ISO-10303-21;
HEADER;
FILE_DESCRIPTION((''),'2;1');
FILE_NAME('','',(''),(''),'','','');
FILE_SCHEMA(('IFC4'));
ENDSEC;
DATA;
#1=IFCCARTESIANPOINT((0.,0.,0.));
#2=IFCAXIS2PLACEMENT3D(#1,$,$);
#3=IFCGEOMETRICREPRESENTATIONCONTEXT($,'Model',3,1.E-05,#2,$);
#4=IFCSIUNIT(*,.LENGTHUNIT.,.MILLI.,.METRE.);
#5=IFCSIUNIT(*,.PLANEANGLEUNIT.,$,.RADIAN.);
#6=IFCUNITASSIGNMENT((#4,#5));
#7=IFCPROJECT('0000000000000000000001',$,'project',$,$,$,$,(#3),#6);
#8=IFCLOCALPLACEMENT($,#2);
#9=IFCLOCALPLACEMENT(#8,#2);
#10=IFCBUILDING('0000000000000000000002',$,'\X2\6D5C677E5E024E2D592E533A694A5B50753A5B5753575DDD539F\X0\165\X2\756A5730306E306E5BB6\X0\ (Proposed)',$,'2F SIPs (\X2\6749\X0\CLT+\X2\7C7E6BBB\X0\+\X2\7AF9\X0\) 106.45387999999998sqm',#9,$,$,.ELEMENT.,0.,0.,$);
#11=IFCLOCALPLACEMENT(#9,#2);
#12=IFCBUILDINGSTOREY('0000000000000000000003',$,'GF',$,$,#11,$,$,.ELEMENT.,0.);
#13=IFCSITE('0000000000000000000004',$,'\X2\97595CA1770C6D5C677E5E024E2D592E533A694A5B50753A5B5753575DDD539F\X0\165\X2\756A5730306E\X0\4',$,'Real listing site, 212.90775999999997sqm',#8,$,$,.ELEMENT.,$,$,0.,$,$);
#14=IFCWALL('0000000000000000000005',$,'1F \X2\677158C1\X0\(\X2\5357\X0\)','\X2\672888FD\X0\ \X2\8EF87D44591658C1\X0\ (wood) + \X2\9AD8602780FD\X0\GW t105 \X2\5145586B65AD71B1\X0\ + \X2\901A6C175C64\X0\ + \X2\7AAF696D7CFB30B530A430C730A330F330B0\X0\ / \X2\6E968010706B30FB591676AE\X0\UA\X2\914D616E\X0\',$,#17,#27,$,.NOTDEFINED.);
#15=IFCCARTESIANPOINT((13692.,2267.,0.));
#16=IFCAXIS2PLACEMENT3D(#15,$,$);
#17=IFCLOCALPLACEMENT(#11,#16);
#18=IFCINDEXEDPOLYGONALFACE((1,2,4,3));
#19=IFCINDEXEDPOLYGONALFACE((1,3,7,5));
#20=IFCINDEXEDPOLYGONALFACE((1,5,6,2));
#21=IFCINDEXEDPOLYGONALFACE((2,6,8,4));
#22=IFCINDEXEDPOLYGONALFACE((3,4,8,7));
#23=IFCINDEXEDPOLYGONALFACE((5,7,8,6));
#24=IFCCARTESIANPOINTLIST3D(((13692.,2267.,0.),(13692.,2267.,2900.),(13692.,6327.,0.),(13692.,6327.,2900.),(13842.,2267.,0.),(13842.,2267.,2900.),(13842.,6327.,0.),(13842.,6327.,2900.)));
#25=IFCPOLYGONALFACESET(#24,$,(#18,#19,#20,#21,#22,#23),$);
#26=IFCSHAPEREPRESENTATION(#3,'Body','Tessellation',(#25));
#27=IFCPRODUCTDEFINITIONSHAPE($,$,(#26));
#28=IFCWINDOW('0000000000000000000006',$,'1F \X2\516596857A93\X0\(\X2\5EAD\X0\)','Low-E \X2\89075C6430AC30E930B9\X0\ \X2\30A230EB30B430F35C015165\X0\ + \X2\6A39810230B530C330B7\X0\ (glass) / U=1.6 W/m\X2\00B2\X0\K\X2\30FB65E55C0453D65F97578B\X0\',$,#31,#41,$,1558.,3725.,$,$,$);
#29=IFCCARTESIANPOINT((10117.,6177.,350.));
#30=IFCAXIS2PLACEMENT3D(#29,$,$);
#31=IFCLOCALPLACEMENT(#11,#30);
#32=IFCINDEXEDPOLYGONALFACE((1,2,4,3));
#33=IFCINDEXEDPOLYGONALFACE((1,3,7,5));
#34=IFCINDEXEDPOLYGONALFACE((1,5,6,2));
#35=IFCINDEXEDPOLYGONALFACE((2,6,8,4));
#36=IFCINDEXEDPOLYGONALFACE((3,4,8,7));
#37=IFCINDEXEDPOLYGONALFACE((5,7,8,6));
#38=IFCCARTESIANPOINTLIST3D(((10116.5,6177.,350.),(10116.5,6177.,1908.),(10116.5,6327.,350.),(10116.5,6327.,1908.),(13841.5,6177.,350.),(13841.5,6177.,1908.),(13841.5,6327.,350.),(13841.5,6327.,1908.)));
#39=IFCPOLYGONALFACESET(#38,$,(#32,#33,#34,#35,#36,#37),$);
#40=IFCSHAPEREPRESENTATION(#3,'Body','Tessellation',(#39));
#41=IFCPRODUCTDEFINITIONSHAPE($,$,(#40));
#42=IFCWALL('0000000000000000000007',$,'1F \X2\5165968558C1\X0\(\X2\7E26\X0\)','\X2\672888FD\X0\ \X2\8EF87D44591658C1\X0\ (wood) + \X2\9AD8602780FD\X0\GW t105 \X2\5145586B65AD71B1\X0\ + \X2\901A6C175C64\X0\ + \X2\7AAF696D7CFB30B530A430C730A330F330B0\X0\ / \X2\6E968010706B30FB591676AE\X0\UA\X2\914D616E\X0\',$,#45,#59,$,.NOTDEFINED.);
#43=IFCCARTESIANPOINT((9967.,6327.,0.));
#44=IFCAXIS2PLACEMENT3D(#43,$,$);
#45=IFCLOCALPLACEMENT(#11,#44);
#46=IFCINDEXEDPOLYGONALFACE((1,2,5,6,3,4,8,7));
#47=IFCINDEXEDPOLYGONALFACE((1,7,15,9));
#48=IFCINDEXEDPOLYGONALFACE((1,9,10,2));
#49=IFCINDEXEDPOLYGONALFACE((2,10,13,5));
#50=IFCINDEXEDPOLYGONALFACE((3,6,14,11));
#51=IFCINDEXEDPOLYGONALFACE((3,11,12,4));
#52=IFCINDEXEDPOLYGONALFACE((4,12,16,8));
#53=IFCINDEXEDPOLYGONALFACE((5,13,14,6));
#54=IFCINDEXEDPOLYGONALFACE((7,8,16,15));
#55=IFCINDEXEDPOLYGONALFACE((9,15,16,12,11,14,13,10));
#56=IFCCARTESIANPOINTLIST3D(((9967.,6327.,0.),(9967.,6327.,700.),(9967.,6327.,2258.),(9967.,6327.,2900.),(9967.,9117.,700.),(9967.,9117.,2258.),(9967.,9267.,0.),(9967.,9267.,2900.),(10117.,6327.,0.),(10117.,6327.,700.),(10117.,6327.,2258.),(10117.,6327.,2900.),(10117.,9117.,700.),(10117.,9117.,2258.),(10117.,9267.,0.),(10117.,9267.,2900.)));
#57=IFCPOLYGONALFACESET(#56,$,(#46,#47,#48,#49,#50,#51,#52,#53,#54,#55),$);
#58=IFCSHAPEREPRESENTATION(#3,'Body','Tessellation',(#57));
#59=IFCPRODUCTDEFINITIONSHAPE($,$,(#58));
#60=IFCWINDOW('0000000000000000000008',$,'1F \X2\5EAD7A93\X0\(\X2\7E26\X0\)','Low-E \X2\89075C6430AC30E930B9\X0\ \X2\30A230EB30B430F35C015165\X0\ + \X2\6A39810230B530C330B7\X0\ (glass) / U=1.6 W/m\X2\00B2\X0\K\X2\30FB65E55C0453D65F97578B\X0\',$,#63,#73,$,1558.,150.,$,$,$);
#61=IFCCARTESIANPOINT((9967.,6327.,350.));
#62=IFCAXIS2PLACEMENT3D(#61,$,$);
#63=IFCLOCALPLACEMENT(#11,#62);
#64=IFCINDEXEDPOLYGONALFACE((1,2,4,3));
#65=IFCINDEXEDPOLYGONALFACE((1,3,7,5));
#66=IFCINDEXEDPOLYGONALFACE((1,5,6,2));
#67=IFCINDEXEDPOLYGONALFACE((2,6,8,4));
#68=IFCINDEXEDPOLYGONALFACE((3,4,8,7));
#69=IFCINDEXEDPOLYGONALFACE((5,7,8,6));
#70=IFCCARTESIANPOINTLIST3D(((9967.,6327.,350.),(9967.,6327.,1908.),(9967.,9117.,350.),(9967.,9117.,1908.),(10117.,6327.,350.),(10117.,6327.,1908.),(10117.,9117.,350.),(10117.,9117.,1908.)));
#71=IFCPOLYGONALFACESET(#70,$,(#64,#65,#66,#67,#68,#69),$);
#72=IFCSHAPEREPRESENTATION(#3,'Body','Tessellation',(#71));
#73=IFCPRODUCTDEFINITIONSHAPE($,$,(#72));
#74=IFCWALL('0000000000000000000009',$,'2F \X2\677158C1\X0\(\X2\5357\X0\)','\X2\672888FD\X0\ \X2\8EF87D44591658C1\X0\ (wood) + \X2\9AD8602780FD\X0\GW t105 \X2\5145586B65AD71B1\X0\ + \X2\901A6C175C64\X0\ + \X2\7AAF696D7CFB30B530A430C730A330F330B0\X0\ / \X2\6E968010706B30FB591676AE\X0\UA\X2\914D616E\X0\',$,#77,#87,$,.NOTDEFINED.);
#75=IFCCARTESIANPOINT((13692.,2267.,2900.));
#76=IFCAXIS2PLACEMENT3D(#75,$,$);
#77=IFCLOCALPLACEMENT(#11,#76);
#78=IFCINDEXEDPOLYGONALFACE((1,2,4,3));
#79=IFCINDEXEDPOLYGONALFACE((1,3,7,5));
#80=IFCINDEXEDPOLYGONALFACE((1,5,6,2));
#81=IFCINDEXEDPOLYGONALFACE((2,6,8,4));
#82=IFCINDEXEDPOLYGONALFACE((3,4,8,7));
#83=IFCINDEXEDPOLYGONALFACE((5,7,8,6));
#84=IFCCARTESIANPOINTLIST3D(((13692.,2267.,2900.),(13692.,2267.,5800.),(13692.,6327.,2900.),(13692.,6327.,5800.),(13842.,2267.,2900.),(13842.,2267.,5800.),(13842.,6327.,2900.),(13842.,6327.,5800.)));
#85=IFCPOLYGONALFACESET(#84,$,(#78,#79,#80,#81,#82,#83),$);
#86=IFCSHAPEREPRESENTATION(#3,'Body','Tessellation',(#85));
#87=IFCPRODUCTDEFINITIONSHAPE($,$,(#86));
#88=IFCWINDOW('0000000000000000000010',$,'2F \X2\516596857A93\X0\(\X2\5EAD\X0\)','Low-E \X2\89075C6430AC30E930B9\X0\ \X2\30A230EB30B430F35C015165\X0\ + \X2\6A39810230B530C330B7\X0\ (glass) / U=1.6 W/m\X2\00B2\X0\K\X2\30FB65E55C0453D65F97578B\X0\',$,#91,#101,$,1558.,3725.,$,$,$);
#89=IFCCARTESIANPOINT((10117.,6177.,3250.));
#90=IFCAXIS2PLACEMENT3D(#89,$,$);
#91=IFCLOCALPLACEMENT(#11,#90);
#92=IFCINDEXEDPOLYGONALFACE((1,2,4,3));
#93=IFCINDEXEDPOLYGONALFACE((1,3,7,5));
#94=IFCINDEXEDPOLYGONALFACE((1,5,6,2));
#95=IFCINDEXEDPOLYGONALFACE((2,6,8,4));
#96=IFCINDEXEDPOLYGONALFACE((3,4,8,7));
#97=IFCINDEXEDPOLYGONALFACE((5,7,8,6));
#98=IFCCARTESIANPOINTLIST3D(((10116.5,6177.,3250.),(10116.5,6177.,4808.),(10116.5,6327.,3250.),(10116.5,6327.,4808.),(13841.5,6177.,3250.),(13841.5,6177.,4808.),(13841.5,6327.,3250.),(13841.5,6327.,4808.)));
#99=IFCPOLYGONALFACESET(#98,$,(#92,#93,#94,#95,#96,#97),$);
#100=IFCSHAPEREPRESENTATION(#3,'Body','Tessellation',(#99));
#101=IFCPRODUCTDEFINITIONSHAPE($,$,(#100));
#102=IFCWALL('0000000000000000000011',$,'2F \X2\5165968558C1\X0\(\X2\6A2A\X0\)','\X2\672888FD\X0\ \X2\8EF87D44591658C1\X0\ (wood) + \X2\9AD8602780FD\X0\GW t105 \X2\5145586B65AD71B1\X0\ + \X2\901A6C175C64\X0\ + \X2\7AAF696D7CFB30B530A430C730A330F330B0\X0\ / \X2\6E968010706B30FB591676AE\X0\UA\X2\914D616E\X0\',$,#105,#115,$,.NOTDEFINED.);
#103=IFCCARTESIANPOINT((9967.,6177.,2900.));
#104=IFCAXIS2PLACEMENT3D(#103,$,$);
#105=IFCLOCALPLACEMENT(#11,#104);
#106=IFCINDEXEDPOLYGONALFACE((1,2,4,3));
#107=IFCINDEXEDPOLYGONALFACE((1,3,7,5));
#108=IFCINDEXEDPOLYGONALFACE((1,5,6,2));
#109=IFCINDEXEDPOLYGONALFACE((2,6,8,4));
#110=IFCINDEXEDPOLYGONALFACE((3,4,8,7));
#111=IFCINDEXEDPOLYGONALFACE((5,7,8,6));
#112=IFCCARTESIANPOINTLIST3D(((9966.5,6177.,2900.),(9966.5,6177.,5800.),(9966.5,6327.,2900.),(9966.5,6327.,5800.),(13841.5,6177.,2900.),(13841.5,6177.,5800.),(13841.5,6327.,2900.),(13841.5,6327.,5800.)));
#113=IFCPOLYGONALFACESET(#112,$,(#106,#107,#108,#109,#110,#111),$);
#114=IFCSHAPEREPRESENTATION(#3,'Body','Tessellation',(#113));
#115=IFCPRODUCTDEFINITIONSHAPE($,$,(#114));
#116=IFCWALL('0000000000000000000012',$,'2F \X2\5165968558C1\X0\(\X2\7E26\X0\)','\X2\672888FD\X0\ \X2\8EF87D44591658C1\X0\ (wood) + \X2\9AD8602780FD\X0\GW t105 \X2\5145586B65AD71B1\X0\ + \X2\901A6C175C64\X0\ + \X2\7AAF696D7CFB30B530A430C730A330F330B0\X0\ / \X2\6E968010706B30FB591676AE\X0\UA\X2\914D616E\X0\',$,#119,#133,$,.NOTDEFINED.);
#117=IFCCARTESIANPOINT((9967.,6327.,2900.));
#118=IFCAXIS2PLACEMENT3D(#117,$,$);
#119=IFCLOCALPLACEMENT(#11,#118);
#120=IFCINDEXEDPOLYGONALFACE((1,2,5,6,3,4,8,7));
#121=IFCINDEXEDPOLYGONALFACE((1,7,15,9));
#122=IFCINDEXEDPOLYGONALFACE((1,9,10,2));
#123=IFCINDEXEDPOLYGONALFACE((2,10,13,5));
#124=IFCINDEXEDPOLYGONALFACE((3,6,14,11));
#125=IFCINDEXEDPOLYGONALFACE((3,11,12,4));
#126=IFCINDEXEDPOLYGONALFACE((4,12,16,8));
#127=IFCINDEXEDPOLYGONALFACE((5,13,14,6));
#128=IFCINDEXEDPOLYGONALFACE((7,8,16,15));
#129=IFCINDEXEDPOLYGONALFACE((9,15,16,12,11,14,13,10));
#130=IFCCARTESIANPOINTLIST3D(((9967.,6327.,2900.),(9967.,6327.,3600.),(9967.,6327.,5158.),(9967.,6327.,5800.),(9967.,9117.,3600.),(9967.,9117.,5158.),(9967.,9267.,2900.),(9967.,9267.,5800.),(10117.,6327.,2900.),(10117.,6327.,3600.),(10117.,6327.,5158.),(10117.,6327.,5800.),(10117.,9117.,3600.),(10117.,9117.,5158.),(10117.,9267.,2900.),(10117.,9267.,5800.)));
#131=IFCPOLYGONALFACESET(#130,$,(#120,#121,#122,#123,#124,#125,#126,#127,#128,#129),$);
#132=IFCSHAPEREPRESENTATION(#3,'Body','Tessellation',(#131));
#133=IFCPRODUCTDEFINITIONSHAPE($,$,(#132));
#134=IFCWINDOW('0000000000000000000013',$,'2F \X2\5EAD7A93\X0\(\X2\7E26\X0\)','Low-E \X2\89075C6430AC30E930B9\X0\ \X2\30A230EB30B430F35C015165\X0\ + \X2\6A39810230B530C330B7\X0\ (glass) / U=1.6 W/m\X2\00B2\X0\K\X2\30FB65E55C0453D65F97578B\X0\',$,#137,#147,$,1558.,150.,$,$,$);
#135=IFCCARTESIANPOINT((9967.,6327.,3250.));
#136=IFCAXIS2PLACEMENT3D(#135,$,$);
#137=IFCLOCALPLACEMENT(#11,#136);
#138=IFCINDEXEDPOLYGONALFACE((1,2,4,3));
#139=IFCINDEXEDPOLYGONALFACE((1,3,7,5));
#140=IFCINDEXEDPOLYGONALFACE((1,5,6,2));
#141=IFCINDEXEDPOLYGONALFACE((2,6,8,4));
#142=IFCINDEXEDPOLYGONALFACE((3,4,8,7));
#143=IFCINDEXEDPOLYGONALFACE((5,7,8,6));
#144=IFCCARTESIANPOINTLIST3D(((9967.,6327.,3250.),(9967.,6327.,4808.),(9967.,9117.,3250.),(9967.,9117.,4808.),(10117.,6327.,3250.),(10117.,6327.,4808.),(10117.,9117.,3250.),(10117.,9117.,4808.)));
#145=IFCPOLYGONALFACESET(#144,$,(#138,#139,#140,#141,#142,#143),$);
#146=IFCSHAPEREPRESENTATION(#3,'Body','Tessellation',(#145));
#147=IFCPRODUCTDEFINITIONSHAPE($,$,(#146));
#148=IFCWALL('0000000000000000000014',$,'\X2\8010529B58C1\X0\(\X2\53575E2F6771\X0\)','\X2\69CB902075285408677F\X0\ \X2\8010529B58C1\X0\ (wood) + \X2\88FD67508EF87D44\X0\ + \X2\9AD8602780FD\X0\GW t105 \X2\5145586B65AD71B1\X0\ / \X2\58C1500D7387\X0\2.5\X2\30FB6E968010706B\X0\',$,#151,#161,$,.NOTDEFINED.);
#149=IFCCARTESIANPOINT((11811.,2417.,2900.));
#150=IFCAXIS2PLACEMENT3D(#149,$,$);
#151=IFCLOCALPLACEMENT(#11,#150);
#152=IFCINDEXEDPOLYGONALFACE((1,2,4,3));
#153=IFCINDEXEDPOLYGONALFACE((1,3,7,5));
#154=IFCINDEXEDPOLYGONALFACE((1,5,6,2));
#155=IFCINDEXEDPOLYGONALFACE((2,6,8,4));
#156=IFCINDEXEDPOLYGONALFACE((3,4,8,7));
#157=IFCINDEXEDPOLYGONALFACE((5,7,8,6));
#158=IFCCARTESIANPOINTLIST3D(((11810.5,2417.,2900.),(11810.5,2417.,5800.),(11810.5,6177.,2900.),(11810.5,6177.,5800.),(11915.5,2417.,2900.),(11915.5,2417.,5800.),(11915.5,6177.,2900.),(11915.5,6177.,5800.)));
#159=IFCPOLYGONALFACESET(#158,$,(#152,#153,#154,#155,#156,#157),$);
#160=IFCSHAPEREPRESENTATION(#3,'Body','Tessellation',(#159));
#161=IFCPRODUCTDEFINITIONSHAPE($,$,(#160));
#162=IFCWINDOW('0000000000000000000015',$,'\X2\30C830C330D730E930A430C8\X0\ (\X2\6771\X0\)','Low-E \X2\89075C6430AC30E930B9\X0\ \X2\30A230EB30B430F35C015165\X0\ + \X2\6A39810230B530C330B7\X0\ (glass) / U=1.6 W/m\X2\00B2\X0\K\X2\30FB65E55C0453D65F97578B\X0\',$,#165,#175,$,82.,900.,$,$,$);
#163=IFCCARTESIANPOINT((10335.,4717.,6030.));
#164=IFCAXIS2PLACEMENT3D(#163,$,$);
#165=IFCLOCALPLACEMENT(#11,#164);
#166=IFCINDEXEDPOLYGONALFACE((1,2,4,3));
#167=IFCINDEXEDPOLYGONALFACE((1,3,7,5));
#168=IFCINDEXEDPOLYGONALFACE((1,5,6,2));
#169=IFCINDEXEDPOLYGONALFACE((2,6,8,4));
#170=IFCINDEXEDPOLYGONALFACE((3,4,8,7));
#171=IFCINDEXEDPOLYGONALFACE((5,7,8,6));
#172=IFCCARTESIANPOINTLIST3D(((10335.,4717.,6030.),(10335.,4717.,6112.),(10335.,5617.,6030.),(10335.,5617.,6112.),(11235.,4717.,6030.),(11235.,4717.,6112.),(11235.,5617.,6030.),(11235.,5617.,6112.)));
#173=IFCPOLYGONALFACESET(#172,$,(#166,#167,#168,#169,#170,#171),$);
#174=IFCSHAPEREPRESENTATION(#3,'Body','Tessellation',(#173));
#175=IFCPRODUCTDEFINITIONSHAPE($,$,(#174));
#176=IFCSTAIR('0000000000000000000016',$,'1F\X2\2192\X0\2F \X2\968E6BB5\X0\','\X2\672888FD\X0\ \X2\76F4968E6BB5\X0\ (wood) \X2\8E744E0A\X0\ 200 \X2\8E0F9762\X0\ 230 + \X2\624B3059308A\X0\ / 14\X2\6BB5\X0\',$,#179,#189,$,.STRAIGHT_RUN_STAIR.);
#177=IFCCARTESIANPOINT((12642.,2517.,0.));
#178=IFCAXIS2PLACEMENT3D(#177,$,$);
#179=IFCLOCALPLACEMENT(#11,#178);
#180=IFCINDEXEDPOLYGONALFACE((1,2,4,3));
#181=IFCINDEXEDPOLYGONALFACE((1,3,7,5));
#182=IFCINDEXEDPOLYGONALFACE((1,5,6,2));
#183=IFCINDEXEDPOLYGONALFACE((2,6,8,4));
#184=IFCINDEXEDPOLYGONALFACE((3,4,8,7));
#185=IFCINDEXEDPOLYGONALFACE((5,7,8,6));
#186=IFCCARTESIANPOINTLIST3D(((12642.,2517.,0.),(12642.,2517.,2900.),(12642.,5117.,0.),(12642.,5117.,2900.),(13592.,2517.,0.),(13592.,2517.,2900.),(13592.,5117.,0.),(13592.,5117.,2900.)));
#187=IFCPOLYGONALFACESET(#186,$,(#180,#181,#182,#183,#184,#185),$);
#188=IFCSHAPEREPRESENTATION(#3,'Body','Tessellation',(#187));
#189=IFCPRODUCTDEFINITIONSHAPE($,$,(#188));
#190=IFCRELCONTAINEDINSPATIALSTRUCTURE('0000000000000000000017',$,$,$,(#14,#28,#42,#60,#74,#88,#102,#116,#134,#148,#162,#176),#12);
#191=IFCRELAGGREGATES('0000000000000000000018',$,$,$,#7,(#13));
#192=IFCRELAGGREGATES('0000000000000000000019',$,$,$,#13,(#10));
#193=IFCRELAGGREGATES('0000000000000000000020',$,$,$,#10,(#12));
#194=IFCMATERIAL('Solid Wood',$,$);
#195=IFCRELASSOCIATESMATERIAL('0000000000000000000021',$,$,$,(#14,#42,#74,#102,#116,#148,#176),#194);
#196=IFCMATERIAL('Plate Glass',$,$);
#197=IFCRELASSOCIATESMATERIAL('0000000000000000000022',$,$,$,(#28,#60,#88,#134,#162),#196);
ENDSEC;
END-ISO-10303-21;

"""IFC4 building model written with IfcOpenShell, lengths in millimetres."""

from ifc_helpers import new_model, si_unit, frame, frame_2d, origin, place, context, project, spatial, rectangle, extrude, material, element, fill, save


model = new_model("IFC4")

# Units and contexts
model_context = context("Model", 3, precision=1e-05, world=origin())
ifc_project = project(units=[si_unit("LENGTHUNIT", "METRE", prefix="MILLI"), si_unit("PLANEANGLEUNIT", "RADIAN")], contexts=[model_context])

# Site, building, storey
site_placement = place(None, origin())
site = spatial("IfcSite", under=ifc_project, at=site_placement, Name="静岡県浜松市中央区楊子町字南川原165番地の4", ObjectType="Real listing site, 212.90775999999997sqm", CompositionType="ELEMENT", RefElevation=0.0)
building_placement = place(site_placement, origin())
building = spatial("IfcBuilding", under=site, at=building_placement, Name="浜松市中央区楊子町字南川原165番地のの家 (Proposed)", ObjectType="2F SIPs (杉CLT+籾殻+竹) 106.45387999999998sqm", CompositionType="ELEMENT", ElevationOfRefHeight=0.0, ElevationOfTerrain=0.0)
storey_placement = place(building_placement, origin())
storey = spatial("IfcBuildingStorey", under=building, at=storey_placement, Name="GF", CompositionType="ELEMENT", Elevation=0.0)

# Shared definitions
ifc_material_1 = material(Name="Solid Wood")

# Wall, opening, window
wall_1_placement = place(storey_placement, frame((13692.0, 2267.0, 0.0)))
wall_1 = element("IfcWall", 1, at=wall_1_placement, inside=storey, material=ifc_material_1, Name="1F 東壁(南)", Description="木製 軸組外壁 (wood) + 高性能GW t105 充填断熱 + 通気層 + 窯業系サイディング / 準耐火・外皮UA配慮", PredefinedType="NOTDEFINED", context=model_context, shape_type="SweptSolid", body=[
    extrude(rectangle(XDim=150.0, YDim=4060.0, at=frame_2d((75.0, 2030.0))), frame((13692.0, 2267.0, 0.0)), (0.0, 0.0, 1.0), 2900.0),
])
opening_1_placement = place(storey_placement, frame((10117.0, 6177.0, 350.0)))
opening_1 = element("IfcOpeningElement", 2, at=opening_1_placement, cuts=wall_1, PredefinedType="NOTDEFINED", context=model_context, shape_type="SweptSolid", body=[
    extrude(rectangle(XDim=3725.0, YDim=150.0, at=frame_2d((1862.0, 75.0))), frame((10117.0, 6177.0, 350.0)), (0.0, 0.0, 1.0), 1558.0),
])
ifc_material_2 = material(Name="Plate Glass")
window_1_placement = place(storey_placement, frame((10117.0, 6177.0, 350.0)))
window_1 = element("IfcWindow", 3, at=window_1_placement, inside=storey, material=ifc_material_2, Name="1F 入隅窓(庭)", Description="Low-E 複層ガラス アルゴン封入 + 樹脂サッシ (glass) / U=1.6 W/m²K・日射取得型", OverallHeight=1558.0, OverallWidth=3725.0, context=model_context, shape_type="SweptSolid", body=[
    extrude(rectangle(XDim=3725.0, YDim=150.0, at=frame_2d((1862.0, 75.0))), frame((10117.0, 6177.0, 350.0)), (0.0, 0.0, 1.0), 1558.0),
])
fill(opening_1, window_1)

# Wall, opening, window
wall_2_placement = place(storey_placement, frame((9967.0, 6327.0, 0.0)))
wall_2 = element("IfcWall", 4, at=wall_2_placement, inside=storey, material=ifc_material_1, Name="1F 入隅壁(縦)", Description="木製 軸組外壁 (wood) + 高性能GW t105 充填断熱 + 通気層 + 窯業系サイディング / 準耐火・外皮UA配慮", PredefinedType="NOTDEFINED", context=model_context, shape_type="SweptSolid", body=[
    extrude(rectangle(XDim=150.0, YDim=2940.0, at=frame_2d((75.0, 1470.0))), frame((9967.0, 6327.0, 0.0)), (0.0, 0.0, 1.0), 2900.0),
])
opening_2_placement = place(storey_placement, frame((9967.0, 6327.0, 350.0)))
opening_2 = element("IfcOpeningElement", 5, at=opening_2_placement, cuts=wall_2, PredefinedType="NOTDEFINED", context=model_context, shape_type="SweptSolid", body=[
    extrude(rectangle(XDim=150.0, YDim=2790.0, at=frame_2d((75.0, 1395.0))), frame((9967.0, 6327.0, 350.0)), (0.0, 0.0, 1.0), 1558.0),
])
window_2_placement = place(storey_placement, frame((9967.0, 6327.0, 350.0)))
window_2 = element("IfcWindow", 6, at=window_2_placement, inside=storey, material=ifc_material_2, Name="1F 庭窓(縦)", Description="Low-E 複層ガラス アルゴン封入 + 樹脂サッシ (glass) / U=1.6 W/m²K・日射取得型", OverallHeight=1558.0, OverallWidth=150.0, context=model_context, shape_type="SweptSolid", body=[
    extrude(rectangle(XDim=150.0, YDim=2790.0, at=frame_2d((75.0, 1395.0))), frame((9967.0, 6327.0, 350.0)), (0.0, 0.0, 1.0), 1558.0),
])
fill(opening_2, window_2)

# Wall, opening, window
wall_3_placement = place(storey_placement, frame((13692.0, 2267.0, 2900.0)))
wall_3 = element("IfcWall", 7, at=wall_3_placement, inside=storey, material=ifc_material_1, Name="2F 東壁(南)", Description="木製 軸組外壁 (wood) + 高性能GW t105 充填断熱 + 通気層 + 窯業系サイディング / 準耐火・外皮UA配慮", PredefinedType="NOTDEFINED", context=model_context, shape_type="SweptSolid", body=[
    extrude(rectangle(XDim=150.0, YDim=4060.0, at=frame_2d((75.0, 2030.0))), frame((13692.0, 2267.0, 2900.0)), (0.0, 0.0, 1.0), 2900.0),
])
opening_3_placement = place(storey_placement, frame((10117.0, 6177.0, 3250.0)))
opening_3 = element("IfcOpeningElement", 8, at=opening_3_placement, cuts=wall_3, PredefinedType="NOTDEFINED", context=model_context, shape_type="SweptSolid", body=[
    extrude(rectangle(XDim=3725.0, YDim=150.0, at=frame_2d((1862.0, 75.0))), frame((10117.0, 6177.0, 3250.0)), (0.0, 0.0, 1.0), 1558.0),
])
window_3_placement = place(storey_placement, frame((10117.0, 6177.0, 3250.0)))
window_3 = element("IfcWindow", 9, at=window_3_placement, inside=storey, material=ifc_material_2, Name="2F 入隅窓(庭)", Description="Low-E 複層ガラス アルゴン封入 + 樹脂サッシ (glass) / U=1.6 W/m²K・日射取得型", OverallHeight=1558.0, OverallWidth=3725.0, context=model_context, shape_type="SweptSolid", body=[
    extrude(rectangle(XDim=3725.0, YDim=150.0, at=frame_2d((1862.0, 75.0))), frame((10117.0, 6177.0, 3250.0)), (0.0, 0.0, 1.0), 1558.0),
])
fill(opening_3, window_3)

# Wall
wall_4_placement = place(storey_placement, frame((9967.0, 6177.0, 2900.0)))
element("IfcWall", 10, at=wall_4_placement, inside=storey, material=ifc_material_1, Name="2F 入隅壁(横)", Description="木製 軸組外壁 (wood) + 高性能GW t105 充填断熱 + 通気層 + 窯業系サイディング / 準耐火・外皮UA配慮", PredefinedType="NOTDEFINED", context=model_context, shape_type="SweptSolid", body=[
    extrude(rectangle(XDim=3875.0, YDim=150.0, at=frame_2d((1937.0, 75.0))), frame((9967.0, 6177.0, 2900.0)), (0.0, 0.0, 1.0), 2900.0),
])

# Wall, opening, window
wall_5_placement = place(storey_placement, frame((9967.0, 6327.0, 2900.0)))
wall_5 = element("IfcWall", 11, at=wall_5_placement, inside=storey, material=ifc_material_1, Name="2F 入隅壁(縦)", Description="木製 軸組外壁 (wood) + 高性能GW t105 充填断熱 + 通気層 + 窯業系サイディング / 準耐火・外皮UA配慮", PredefinedType="NOTDEFINED", context=model_context, shape_type="SweptSolid", body=[
    extrude(rectangle(XDim=150.0, YDim=2940.0, at=frame_2d((75.0, 1470.0))), frame((9967.0, 6327.0, 2900.0)), (0.0, 0.0, 1.0), 2900.0),
])
opening_4_placement = place(storey_placement, frame((9967.0, 6327.0, 3250.0)))
opening_4 = element("IfcOpeningElement", 12, at=opening_4_placement, cuts=wall_5, PredefinedType="NOTDEFINED", context=model_context, shape_type="SweptSolid", body=[
    extrude(rectangle(XDim=150.0, YDim=2790.0, at=frame_2d((75.0, 1395.0))), frame((9967.0, 6327.0, 3250.0)), (0.0, 0.0, 1.0), 1558.0),
])
window_4_placement = place(storey_placement, frame((9967.0, 6327.0, 3250.0)))
window_4 = element("IfcWindow", 13, at=window_4_placement, inside=storey, material=ifc_material_2, Name="2F 庭窓(縦)", Description="Low-E 複層ガラス アルゴン封入 + 樹脂サッシ (glass) / U=1.6 W/m²K・日射取得型", OverallHeight=1558.0, OverallWidth=150.0, context=model_context, shape_type="SweptSolid", body=[
    extrude(rectangle(XDim=150.0, YDim=2790.0, at=frame_2d((75.0, 1395.0))), frame((9967.0, 6327.0, 3250.0)), (0.0, 0.0, 1.0), 1558.0),
])
fill(opening_4, window_4)

# Wall
wall_6_placement = place(storey_placement, frame((11811.0, 2417.0, 2900.0)))
element("IfcWall", 14, at=wall_6_placement, inside=storey, material=ifc_material_1, Name="耐力壁(南帯東)", Description="構造用合板 耐力壁 (wood) + 製材軸組 + 高性能GW t105 充填断熱 / 壁倍率2.5・準耐火", PredefinedType="NOTDEFINED", context=model_context, shape_type="SweptSolid", body=[
    extrude(rectangle(XDim=105.0, YDim=3760.0, at=frame_2d((52.0, 1880.0))), frame((11811.0, 2417.0, 2900.0)), (0.0, 0.0, 1.0), 2900.0),
])

# Window
window_5_placement = place(storey_placement, frame((10335.0, 4717.0, 6030.0)))
element("IfcWindow", 15, at=window_5_placement, inside=storey, material=ifc_material_2, Name="トップライト (東)", Description="Low-E 複層ガラス アルゴン封入 + 樹脂サッシ (glass) / U=1.6 W/m²K・日射取得型", OverallHeight=82.0, OverallWidth=900.0, context=model_context, shape_type="SweptSolid", body=[
    extrude(rectangle(XDim=900.0, YDim=900.0, at=frame_2d((450.0, 450.0))), frame((10335.0, 4717.0, 6030.0)), (0.0, 0.0, 1.0), 82.0),
])

# Stair
stair_placement = place(storey_placement, frame((12642.0, 2517.0, 0.0)))
element("IfcStair", 16, at=stair_placement, inside=storey, material=ifc_material_1, Name="1F→2F 階段", Description="木製 直階段 (wood) 蹴上 200 踏面 230 + 手すり / 14段", PredefinedType="STRAIGHT_RUN_STAIR", context=model_context, shape_type="SweptSolid", body=[
    extrude(rectangle(XDim=950.0, YDim=2600.0, at=frame_2d((475.0, 1300.0))), frame((12642.0, 2517.0, 0.0)), (0.0, 0.0, 1.0), 2900.0),
])

save(model, "model.ifc")
